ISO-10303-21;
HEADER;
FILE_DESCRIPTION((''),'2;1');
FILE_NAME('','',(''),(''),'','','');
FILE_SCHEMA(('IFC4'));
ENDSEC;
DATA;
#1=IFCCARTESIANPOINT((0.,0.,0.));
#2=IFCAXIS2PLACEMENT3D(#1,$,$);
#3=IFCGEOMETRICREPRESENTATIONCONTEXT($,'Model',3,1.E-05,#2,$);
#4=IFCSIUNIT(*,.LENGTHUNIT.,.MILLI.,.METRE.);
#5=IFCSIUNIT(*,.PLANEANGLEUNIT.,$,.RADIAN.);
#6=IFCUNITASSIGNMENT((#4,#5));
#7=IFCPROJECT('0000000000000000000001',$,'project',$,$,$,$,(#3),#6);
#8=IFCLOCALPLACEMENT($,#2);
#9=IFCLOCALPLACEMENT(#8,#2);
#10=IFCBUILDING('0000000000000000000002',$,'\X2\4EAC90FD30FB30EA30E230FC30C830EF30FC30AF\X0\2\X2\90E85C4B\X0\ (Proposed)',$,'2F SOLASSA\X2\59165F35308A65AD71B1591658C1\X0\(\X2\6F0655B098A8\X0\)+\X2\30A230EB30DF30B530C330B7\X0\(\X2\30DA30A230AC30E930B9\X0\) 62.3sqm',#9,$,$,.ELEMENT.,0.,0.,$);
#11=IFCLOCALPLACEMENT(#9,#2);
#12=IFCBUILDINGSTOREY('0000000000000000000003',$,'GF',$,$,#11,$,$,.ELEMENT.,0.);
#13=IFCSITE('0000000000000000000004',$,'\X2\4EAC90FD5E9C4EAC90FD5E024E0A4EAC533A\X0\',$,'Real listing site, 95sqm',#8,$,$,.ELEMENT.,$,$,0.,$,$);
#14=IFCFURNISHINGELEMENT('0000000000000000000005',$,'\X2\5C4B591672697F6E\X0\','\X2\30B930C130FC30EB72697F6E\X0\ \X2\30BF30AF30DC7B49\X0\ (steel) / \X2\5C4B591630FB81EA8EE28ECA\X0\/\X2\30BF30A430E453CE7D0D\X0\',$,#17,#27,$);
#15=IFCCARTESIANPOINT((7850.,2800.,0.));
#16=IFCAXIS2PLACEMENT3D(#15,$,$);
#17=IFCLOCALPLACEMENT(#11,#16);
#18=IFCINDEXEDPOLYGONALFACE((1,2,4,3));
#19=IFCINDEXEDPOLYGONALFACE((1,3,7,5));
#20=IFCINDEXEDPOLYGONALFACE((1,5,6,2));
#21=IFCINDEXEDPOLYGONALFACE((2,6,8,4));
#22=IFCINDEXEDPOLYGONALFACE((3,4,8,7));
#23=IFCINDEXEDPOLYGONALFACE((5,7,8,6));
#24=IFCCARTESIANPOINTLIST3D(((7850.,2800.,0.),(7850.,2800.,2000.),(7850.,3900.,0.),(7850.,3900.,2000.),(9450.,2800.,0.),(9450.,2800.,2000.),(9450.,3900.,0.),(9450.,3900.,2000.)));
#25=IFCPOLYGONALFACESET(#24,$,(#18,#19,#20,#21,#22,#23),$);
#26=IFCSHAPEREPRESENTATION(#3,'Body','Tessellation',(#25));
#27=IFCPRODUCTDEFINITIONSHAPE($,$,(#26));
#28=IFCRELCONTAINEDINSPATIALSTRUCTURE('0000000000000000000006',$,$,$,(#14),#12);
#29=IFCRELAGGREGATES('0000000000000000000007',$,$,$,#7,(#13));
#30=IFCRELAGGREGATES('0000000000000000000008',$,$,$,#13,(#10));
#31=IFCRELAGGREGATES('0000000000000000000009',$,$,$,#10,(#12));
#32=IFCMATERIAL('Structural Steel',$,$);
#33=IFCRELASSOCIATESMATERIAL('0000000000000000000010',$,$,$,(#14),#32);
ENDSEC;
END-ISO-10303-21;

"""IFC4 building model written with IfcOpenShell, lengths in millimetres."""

from ifc_helpers import new_model, si_unit, frame, frame_2d, origin, place, context, project, spatial, rectangle, extrude, material, element, save


model = new_model("IFC4")

# Units and contexts
model_context = context("Model", 3, precision=1e-05, world=origin())
ifc_project = project(units=[si_unit("LENGTHUNIT", "METRE", prefix="MILLI"), si_unit("PLANEANGLEUNIT", "RADIAN")], contexts=[model_context])

# Site, building, storey
site_placement = place(None, origin())
site = spatial("IfcSite", under=ifc_project, at=site_placement, Name="京都府京都市上京区", ObjectType="Real listing site, 95sqm", CompositionType="ELEMENT", RefElevation=0.0)
building_placement = place(site_placement, origin())
building = spatial("IfcBuilding", under=site, at=building_placement, Name="京都・リモートワーク2部屋 (Proposed)", ObjectType="2F SOLASSA外張り断熱外壁(漆喰風)+アルミサッシ(ペアガラス) 62.3sqm", CompositionType="ELEMENT", ElevationOfRefHeight=0.0, ElevationOfTerrain=0.0)
storey_placement = place(building_placement, origin())
storey = spatial("IfcBuildingStorey", under=building, at=storey_placement, Name="GF", CompositionType="ELEMENT", Elevation=0.0)

# Shared definitions
ifc_material_1 = material(Name="Structural Steel")

# Furnishing element
furnishing_1_placement = place(storey_placement, frame((7850.0, 2800.0, 0.0)))
element("IfcFurnishingElement", 1, at=furnishing_1_placement, inside=storey, material=ifc_material_1, Name="屋外物置", Description="スチール物置 タクボ等 (steel) / 屋外・自転車/タイヤ収納", context=model_context, shape_type="SweptSolid", body=[
    extrude(rectangle(XDim=1600.0, YDim=1100.0, at=frame_2d((800.0, 550.0))), frame((7850.0, 2800.0, 0.0)), (0.0, 0.0, 1.0), 2000.0),
])

save(model, "model.ifc")
